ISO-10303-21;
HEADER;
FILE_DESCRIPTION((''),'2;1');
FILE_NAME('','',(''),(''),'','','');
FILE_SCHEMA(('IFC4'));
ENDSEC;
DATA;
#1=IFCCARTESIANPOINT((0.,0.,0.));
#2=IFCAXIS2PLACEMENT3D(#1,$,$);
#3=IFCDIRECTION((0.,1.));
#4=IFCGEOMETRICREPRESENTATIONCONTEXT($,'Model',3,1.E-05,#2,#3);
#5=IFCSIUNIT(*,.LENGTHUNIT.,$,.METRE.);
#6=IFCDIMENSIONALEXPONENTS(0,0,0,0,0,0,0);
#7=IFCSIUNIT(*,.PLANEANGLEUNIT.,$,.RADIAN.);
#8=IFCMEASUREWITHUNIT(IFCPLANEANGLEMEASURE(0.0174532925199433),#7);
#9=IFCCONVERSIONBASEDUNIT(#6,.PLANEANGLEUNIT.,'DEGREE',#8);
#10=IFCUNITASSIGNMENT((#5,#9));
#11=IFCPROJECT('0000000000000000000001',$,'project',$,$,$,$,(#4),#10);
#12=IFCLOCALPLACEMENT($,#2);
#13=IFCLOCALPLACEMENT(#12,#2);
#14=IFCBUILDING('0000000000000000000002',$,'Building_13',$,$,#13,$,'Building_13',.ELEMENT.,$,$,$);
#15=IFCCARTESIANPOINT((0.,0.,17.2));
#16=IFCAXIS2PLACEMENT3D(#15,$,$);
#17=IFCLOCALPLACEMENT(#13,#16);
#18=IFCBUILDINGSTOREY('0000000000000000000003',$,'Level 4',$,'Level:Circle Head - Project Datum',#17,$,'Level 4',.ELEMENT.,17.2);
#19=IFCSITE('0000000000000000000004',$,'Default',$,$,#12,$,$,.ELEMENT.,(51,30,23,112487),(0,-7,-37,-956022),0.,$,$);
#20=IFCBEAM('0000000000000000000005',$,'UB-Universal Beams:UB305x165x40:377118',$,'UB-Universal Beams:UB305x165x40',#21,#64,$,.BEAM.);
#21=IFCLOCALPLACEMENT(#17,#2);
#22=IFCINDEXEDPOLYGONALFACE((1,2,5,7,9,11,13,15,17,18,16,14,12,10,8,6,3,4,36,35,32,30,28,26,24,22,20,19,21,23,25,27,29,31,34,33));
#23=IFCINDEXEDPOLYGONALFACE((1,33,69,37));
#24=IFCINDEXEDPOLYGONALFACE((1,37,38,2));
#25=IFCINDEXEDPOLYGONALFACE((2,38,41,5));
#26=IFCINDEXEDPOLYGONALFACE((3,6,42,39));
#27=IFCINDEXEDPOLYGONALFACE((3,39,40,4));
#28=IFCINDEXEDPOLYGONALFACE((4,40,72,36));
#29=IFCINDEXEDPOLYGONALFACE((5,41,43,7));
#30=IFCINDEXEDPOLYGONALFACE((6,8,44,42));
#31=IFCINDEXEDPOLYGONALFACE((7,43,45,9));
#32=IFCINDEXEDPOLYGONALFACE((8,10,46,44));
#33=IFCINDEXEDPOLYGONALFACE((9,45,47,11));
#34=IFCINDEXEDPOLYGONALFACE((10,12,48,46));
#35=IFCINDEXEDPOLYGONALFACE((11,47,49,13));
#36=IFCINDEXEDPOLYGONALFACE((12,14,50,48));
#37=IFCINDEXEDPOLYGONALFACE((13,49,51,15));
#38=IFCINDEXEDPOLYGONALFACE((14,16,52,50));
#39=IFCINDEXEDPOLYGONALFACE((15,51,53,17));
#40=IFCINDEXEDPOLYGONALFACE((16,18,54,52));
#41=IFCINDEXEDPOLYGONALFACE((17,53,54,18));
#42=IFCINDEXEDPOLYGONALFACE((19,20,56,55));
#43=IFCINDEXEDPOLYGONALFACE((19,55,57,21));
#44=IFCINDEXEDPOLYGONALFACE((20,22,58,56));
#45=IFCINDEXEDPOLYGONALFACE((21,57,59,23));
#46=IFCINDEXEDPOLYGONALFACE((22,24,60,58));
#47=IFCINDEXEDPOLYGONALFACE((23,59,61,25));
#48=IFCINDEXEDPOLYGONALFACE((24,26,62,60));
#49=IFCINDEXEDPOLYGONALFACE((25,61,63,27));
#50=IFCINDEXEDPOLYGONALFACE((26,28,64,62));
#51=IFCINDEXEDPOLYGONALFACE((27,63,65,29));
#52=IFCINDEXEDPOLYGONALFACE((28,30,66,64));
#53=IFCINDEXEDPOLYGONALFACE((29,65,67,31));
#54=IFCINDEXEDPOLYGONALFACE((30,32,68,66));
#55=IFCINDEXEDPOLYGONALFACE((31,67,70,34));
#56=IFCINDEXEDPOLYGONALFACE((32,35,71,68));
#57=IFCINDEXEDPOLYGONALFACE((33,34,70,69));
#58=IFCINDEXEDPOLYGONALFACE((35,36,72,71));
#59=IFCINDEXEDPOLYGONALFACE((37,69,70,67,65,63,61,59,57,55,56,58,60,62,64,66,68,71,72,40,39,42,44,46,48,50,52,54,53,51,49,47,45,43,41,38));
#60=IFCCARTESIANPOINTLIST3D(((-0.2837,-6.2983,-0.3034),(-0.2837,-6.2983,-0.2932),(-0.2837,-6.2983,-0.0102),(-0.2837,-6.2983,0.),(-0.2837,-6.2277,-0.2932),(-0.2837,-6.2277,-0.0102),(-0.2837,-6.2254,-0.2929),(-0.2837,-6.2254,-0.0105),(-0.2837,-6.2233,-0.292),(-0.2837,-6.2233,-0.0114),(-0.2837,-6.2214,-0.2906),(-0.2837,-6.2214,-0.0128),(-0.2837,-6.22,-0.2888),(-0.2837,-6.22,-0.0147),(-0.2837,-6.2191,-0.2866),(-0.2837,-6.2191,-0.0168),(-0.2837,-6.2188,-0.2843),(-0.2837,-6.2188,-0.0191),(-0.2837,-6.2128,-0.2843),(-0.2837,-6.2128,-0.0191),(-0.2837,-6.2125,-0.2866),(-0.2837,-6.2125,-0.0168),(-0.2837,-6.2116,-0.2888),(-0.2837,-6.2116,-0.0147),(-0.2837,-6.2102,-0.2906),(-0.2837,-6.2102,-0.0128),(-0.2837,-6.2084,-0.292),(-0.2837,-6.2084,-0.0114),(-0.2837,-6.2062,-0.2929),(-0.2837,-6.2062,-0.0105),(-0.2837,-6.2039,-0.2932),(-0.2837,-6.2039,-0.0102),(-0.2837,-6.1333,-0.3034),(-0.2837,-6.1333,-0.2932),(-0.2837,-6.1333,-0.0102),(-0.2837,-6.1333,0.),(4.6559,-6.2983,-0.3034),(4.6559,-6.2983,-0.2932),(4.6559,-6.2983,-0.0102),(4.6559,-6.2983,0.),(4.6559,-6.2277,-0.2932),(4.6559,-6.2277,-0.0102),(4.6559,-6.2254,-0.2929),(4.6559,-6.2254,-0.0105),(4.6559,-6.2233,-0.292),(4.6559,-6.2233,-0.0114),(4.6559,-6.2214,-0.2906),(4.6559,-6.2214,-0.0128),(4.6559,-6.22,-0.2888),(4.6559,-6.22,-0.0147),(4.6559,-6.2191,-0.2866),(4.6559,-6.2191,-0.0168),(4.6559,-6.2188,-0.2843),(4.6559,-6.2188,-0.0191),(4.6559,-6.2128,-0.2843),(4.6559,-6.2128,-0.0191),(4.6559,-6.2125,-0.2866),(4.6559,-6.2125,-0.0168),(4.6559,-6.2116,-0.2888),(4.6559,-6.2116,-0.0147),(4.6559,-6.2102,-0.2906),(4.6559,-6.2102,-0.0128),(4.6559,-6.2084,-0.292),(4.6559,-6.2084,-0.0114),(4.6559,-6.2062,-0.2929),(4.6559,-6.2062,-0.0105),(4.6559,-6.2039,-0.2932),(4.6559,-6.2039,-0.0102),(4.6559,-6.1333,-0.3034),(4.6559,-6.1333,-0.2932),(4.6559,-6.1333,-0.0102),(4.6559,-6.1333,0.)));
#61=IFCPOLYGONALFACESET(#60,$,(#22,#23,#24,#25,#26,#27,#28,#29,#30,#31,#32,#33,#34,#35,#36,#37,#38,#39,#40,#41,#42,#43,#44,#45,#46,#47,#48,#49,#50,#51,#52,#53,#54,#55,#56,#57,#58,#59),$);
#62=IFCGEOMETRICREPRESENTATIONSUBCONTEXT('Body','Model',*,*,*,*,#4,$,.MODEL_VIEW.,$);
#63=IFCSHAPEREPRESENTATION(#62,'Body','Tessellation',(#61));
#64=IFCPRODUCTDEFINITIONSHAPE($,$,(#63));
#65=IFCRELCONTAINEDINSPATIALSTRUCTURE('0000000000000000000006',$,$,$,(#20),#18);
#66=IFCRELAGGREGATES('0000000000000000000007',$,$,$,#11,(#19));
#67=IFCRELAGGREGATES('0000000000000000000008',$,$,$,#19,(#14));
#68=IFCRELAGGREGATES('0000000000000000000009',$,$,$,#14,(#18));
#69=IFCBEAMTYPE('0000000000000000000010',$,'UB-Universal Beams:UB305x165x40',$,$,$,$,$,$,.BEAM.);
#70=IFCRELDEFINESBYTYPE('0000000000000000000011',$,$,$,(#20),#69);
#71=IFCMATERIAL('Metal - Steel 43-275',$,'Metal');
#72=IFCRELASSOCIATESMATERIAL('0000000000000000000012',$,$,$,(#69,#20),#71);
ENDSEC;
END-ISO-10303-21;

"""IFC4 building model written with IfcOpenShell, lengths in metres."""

from ifc_helpers import new_model, entity, si_unit, converted_unit, direction, frame, origin, place, context, subcontext, project, spatial, line, arc, indexed_curve, outline, extrude, source, transform, mapped, material, type_object, type_shapes, element, save


model = new_model("IFC4")

# Units and contexts
model_context = context("Model", 3, precision=1e-05, world=origin(), true_north=direction((0.0, 1.0)))
body_context = subcontext(model_context, "Body", "Model", "MODEL_VIEW")
ifc_project = project(units=[si_unit("LENGTHUNIT", "METRE"), converted_unit("PLANEANGLEUNIT", "DEGREE", entity("IfcPlaneAngleMeasure", 0.0174532925199433), si_unit("PLANEANGLEUNIT", "RADIAN"), dimensions=[0, 0, 0, 0, 0, 0, 0])], contexts=[model_context])

# Site, building, storey
site_placement = place(None, origin())
site = spatial("IfcSite", under=ifc_project, at=site_placement, Name="Default", CompositionType="ELEMENT", RefLatitude=(51, 30, 23, 112487), RefLongitude=(0, -7, -37, -956022), RefElevation=0.0)
building_placement = place(site_placement, origin())
building = spatial("IfcBuilding", under=site, at=building_placement, Name="Building_13", LongName="Building_13", CompositionType="ELEMENT")
storey_placement = place(building_placement, frame((0.0, 0.0, 17.2)))
storey = spatial("IfcBuildingStorey", under=building, at=storey_placement, Name="Level 4", ObjectType="Level:Circle Head - Project Datum", LongName="Level 4", CompositionType="ELEMENT", Elevation=17.2)

# Beam
ifc_material_1 = material(Name="Metal - Steel 43-275", Category="Metal")
beam_type_1 = type_object("IfcBeamType", Name="UB-Universal Beams:UB305x165x40", PredefinedType="BEAM", material=ifc_material_1)
shared_shape_1 = source(origin(), body_context, "Body", "SweptSolid", [
    extrude(outline(indexed_curve([(-0.0825, -0.1415), (-0.0825, -0.1517), (0.0825, -0.1517), (0.0825, -0.1415), (0.0119, -0.1415), (0.0056, -0.1389), (0.003, -0.1326), (0.003, 0.1326), (0.0056, 0.1389), (0.0119, 0.1415), (0.0825, 0.1415), (0.0825, 0.1517), (-0.0825, 0.1517), (-0.0825, 0.1415), (-0.0119, 0.1415), (-0.0056, 0.1389), (-0.003, 0.1326), (-0.003, -0.1326), (-0.0056, -0.1389), (-0.0119, -0.1415)], segments=[line(1, 2, 3, 4, 5), arc(5, 6, 7), line(7, 8), arc(8, 9, 10), line(10, 11, 12, 13, 14, 15), arc(15, 16, 17), line(17, 18), arc(18, 19, 20), line(20, 1)], self_intersect=False)), frame((-2.3846, 0.0, 0.0), z_axis=(-1.0, 0.0, 0.0), x_axis=(0.0, -1.0, 0.0)), (0.0, 0.0, -1.0), 4.9396),
])
type_shapes(beam_type_1, [shared_shape_1])
beam_1_placement = place(storey_placement, frame((2.1009, -6.2158, -0.1517)))
element("IfcBeam", 1, at=beam_1_placement, inside=storey, type_object=beam_type_1, material=ifc_material_1, Name="UB-Universal Beams:UB305x165x40:377118", ObjectType="UB-Universal Beams:UB305x165x40", PredefinedType="BEAM", context=body_context, shape_type="MappedRepresentation", body=[
    mapped(shared_shape_1, transform((0.0, 0.0, 0.0), scale=1.0)),
])

save(model, "model.ifc")
